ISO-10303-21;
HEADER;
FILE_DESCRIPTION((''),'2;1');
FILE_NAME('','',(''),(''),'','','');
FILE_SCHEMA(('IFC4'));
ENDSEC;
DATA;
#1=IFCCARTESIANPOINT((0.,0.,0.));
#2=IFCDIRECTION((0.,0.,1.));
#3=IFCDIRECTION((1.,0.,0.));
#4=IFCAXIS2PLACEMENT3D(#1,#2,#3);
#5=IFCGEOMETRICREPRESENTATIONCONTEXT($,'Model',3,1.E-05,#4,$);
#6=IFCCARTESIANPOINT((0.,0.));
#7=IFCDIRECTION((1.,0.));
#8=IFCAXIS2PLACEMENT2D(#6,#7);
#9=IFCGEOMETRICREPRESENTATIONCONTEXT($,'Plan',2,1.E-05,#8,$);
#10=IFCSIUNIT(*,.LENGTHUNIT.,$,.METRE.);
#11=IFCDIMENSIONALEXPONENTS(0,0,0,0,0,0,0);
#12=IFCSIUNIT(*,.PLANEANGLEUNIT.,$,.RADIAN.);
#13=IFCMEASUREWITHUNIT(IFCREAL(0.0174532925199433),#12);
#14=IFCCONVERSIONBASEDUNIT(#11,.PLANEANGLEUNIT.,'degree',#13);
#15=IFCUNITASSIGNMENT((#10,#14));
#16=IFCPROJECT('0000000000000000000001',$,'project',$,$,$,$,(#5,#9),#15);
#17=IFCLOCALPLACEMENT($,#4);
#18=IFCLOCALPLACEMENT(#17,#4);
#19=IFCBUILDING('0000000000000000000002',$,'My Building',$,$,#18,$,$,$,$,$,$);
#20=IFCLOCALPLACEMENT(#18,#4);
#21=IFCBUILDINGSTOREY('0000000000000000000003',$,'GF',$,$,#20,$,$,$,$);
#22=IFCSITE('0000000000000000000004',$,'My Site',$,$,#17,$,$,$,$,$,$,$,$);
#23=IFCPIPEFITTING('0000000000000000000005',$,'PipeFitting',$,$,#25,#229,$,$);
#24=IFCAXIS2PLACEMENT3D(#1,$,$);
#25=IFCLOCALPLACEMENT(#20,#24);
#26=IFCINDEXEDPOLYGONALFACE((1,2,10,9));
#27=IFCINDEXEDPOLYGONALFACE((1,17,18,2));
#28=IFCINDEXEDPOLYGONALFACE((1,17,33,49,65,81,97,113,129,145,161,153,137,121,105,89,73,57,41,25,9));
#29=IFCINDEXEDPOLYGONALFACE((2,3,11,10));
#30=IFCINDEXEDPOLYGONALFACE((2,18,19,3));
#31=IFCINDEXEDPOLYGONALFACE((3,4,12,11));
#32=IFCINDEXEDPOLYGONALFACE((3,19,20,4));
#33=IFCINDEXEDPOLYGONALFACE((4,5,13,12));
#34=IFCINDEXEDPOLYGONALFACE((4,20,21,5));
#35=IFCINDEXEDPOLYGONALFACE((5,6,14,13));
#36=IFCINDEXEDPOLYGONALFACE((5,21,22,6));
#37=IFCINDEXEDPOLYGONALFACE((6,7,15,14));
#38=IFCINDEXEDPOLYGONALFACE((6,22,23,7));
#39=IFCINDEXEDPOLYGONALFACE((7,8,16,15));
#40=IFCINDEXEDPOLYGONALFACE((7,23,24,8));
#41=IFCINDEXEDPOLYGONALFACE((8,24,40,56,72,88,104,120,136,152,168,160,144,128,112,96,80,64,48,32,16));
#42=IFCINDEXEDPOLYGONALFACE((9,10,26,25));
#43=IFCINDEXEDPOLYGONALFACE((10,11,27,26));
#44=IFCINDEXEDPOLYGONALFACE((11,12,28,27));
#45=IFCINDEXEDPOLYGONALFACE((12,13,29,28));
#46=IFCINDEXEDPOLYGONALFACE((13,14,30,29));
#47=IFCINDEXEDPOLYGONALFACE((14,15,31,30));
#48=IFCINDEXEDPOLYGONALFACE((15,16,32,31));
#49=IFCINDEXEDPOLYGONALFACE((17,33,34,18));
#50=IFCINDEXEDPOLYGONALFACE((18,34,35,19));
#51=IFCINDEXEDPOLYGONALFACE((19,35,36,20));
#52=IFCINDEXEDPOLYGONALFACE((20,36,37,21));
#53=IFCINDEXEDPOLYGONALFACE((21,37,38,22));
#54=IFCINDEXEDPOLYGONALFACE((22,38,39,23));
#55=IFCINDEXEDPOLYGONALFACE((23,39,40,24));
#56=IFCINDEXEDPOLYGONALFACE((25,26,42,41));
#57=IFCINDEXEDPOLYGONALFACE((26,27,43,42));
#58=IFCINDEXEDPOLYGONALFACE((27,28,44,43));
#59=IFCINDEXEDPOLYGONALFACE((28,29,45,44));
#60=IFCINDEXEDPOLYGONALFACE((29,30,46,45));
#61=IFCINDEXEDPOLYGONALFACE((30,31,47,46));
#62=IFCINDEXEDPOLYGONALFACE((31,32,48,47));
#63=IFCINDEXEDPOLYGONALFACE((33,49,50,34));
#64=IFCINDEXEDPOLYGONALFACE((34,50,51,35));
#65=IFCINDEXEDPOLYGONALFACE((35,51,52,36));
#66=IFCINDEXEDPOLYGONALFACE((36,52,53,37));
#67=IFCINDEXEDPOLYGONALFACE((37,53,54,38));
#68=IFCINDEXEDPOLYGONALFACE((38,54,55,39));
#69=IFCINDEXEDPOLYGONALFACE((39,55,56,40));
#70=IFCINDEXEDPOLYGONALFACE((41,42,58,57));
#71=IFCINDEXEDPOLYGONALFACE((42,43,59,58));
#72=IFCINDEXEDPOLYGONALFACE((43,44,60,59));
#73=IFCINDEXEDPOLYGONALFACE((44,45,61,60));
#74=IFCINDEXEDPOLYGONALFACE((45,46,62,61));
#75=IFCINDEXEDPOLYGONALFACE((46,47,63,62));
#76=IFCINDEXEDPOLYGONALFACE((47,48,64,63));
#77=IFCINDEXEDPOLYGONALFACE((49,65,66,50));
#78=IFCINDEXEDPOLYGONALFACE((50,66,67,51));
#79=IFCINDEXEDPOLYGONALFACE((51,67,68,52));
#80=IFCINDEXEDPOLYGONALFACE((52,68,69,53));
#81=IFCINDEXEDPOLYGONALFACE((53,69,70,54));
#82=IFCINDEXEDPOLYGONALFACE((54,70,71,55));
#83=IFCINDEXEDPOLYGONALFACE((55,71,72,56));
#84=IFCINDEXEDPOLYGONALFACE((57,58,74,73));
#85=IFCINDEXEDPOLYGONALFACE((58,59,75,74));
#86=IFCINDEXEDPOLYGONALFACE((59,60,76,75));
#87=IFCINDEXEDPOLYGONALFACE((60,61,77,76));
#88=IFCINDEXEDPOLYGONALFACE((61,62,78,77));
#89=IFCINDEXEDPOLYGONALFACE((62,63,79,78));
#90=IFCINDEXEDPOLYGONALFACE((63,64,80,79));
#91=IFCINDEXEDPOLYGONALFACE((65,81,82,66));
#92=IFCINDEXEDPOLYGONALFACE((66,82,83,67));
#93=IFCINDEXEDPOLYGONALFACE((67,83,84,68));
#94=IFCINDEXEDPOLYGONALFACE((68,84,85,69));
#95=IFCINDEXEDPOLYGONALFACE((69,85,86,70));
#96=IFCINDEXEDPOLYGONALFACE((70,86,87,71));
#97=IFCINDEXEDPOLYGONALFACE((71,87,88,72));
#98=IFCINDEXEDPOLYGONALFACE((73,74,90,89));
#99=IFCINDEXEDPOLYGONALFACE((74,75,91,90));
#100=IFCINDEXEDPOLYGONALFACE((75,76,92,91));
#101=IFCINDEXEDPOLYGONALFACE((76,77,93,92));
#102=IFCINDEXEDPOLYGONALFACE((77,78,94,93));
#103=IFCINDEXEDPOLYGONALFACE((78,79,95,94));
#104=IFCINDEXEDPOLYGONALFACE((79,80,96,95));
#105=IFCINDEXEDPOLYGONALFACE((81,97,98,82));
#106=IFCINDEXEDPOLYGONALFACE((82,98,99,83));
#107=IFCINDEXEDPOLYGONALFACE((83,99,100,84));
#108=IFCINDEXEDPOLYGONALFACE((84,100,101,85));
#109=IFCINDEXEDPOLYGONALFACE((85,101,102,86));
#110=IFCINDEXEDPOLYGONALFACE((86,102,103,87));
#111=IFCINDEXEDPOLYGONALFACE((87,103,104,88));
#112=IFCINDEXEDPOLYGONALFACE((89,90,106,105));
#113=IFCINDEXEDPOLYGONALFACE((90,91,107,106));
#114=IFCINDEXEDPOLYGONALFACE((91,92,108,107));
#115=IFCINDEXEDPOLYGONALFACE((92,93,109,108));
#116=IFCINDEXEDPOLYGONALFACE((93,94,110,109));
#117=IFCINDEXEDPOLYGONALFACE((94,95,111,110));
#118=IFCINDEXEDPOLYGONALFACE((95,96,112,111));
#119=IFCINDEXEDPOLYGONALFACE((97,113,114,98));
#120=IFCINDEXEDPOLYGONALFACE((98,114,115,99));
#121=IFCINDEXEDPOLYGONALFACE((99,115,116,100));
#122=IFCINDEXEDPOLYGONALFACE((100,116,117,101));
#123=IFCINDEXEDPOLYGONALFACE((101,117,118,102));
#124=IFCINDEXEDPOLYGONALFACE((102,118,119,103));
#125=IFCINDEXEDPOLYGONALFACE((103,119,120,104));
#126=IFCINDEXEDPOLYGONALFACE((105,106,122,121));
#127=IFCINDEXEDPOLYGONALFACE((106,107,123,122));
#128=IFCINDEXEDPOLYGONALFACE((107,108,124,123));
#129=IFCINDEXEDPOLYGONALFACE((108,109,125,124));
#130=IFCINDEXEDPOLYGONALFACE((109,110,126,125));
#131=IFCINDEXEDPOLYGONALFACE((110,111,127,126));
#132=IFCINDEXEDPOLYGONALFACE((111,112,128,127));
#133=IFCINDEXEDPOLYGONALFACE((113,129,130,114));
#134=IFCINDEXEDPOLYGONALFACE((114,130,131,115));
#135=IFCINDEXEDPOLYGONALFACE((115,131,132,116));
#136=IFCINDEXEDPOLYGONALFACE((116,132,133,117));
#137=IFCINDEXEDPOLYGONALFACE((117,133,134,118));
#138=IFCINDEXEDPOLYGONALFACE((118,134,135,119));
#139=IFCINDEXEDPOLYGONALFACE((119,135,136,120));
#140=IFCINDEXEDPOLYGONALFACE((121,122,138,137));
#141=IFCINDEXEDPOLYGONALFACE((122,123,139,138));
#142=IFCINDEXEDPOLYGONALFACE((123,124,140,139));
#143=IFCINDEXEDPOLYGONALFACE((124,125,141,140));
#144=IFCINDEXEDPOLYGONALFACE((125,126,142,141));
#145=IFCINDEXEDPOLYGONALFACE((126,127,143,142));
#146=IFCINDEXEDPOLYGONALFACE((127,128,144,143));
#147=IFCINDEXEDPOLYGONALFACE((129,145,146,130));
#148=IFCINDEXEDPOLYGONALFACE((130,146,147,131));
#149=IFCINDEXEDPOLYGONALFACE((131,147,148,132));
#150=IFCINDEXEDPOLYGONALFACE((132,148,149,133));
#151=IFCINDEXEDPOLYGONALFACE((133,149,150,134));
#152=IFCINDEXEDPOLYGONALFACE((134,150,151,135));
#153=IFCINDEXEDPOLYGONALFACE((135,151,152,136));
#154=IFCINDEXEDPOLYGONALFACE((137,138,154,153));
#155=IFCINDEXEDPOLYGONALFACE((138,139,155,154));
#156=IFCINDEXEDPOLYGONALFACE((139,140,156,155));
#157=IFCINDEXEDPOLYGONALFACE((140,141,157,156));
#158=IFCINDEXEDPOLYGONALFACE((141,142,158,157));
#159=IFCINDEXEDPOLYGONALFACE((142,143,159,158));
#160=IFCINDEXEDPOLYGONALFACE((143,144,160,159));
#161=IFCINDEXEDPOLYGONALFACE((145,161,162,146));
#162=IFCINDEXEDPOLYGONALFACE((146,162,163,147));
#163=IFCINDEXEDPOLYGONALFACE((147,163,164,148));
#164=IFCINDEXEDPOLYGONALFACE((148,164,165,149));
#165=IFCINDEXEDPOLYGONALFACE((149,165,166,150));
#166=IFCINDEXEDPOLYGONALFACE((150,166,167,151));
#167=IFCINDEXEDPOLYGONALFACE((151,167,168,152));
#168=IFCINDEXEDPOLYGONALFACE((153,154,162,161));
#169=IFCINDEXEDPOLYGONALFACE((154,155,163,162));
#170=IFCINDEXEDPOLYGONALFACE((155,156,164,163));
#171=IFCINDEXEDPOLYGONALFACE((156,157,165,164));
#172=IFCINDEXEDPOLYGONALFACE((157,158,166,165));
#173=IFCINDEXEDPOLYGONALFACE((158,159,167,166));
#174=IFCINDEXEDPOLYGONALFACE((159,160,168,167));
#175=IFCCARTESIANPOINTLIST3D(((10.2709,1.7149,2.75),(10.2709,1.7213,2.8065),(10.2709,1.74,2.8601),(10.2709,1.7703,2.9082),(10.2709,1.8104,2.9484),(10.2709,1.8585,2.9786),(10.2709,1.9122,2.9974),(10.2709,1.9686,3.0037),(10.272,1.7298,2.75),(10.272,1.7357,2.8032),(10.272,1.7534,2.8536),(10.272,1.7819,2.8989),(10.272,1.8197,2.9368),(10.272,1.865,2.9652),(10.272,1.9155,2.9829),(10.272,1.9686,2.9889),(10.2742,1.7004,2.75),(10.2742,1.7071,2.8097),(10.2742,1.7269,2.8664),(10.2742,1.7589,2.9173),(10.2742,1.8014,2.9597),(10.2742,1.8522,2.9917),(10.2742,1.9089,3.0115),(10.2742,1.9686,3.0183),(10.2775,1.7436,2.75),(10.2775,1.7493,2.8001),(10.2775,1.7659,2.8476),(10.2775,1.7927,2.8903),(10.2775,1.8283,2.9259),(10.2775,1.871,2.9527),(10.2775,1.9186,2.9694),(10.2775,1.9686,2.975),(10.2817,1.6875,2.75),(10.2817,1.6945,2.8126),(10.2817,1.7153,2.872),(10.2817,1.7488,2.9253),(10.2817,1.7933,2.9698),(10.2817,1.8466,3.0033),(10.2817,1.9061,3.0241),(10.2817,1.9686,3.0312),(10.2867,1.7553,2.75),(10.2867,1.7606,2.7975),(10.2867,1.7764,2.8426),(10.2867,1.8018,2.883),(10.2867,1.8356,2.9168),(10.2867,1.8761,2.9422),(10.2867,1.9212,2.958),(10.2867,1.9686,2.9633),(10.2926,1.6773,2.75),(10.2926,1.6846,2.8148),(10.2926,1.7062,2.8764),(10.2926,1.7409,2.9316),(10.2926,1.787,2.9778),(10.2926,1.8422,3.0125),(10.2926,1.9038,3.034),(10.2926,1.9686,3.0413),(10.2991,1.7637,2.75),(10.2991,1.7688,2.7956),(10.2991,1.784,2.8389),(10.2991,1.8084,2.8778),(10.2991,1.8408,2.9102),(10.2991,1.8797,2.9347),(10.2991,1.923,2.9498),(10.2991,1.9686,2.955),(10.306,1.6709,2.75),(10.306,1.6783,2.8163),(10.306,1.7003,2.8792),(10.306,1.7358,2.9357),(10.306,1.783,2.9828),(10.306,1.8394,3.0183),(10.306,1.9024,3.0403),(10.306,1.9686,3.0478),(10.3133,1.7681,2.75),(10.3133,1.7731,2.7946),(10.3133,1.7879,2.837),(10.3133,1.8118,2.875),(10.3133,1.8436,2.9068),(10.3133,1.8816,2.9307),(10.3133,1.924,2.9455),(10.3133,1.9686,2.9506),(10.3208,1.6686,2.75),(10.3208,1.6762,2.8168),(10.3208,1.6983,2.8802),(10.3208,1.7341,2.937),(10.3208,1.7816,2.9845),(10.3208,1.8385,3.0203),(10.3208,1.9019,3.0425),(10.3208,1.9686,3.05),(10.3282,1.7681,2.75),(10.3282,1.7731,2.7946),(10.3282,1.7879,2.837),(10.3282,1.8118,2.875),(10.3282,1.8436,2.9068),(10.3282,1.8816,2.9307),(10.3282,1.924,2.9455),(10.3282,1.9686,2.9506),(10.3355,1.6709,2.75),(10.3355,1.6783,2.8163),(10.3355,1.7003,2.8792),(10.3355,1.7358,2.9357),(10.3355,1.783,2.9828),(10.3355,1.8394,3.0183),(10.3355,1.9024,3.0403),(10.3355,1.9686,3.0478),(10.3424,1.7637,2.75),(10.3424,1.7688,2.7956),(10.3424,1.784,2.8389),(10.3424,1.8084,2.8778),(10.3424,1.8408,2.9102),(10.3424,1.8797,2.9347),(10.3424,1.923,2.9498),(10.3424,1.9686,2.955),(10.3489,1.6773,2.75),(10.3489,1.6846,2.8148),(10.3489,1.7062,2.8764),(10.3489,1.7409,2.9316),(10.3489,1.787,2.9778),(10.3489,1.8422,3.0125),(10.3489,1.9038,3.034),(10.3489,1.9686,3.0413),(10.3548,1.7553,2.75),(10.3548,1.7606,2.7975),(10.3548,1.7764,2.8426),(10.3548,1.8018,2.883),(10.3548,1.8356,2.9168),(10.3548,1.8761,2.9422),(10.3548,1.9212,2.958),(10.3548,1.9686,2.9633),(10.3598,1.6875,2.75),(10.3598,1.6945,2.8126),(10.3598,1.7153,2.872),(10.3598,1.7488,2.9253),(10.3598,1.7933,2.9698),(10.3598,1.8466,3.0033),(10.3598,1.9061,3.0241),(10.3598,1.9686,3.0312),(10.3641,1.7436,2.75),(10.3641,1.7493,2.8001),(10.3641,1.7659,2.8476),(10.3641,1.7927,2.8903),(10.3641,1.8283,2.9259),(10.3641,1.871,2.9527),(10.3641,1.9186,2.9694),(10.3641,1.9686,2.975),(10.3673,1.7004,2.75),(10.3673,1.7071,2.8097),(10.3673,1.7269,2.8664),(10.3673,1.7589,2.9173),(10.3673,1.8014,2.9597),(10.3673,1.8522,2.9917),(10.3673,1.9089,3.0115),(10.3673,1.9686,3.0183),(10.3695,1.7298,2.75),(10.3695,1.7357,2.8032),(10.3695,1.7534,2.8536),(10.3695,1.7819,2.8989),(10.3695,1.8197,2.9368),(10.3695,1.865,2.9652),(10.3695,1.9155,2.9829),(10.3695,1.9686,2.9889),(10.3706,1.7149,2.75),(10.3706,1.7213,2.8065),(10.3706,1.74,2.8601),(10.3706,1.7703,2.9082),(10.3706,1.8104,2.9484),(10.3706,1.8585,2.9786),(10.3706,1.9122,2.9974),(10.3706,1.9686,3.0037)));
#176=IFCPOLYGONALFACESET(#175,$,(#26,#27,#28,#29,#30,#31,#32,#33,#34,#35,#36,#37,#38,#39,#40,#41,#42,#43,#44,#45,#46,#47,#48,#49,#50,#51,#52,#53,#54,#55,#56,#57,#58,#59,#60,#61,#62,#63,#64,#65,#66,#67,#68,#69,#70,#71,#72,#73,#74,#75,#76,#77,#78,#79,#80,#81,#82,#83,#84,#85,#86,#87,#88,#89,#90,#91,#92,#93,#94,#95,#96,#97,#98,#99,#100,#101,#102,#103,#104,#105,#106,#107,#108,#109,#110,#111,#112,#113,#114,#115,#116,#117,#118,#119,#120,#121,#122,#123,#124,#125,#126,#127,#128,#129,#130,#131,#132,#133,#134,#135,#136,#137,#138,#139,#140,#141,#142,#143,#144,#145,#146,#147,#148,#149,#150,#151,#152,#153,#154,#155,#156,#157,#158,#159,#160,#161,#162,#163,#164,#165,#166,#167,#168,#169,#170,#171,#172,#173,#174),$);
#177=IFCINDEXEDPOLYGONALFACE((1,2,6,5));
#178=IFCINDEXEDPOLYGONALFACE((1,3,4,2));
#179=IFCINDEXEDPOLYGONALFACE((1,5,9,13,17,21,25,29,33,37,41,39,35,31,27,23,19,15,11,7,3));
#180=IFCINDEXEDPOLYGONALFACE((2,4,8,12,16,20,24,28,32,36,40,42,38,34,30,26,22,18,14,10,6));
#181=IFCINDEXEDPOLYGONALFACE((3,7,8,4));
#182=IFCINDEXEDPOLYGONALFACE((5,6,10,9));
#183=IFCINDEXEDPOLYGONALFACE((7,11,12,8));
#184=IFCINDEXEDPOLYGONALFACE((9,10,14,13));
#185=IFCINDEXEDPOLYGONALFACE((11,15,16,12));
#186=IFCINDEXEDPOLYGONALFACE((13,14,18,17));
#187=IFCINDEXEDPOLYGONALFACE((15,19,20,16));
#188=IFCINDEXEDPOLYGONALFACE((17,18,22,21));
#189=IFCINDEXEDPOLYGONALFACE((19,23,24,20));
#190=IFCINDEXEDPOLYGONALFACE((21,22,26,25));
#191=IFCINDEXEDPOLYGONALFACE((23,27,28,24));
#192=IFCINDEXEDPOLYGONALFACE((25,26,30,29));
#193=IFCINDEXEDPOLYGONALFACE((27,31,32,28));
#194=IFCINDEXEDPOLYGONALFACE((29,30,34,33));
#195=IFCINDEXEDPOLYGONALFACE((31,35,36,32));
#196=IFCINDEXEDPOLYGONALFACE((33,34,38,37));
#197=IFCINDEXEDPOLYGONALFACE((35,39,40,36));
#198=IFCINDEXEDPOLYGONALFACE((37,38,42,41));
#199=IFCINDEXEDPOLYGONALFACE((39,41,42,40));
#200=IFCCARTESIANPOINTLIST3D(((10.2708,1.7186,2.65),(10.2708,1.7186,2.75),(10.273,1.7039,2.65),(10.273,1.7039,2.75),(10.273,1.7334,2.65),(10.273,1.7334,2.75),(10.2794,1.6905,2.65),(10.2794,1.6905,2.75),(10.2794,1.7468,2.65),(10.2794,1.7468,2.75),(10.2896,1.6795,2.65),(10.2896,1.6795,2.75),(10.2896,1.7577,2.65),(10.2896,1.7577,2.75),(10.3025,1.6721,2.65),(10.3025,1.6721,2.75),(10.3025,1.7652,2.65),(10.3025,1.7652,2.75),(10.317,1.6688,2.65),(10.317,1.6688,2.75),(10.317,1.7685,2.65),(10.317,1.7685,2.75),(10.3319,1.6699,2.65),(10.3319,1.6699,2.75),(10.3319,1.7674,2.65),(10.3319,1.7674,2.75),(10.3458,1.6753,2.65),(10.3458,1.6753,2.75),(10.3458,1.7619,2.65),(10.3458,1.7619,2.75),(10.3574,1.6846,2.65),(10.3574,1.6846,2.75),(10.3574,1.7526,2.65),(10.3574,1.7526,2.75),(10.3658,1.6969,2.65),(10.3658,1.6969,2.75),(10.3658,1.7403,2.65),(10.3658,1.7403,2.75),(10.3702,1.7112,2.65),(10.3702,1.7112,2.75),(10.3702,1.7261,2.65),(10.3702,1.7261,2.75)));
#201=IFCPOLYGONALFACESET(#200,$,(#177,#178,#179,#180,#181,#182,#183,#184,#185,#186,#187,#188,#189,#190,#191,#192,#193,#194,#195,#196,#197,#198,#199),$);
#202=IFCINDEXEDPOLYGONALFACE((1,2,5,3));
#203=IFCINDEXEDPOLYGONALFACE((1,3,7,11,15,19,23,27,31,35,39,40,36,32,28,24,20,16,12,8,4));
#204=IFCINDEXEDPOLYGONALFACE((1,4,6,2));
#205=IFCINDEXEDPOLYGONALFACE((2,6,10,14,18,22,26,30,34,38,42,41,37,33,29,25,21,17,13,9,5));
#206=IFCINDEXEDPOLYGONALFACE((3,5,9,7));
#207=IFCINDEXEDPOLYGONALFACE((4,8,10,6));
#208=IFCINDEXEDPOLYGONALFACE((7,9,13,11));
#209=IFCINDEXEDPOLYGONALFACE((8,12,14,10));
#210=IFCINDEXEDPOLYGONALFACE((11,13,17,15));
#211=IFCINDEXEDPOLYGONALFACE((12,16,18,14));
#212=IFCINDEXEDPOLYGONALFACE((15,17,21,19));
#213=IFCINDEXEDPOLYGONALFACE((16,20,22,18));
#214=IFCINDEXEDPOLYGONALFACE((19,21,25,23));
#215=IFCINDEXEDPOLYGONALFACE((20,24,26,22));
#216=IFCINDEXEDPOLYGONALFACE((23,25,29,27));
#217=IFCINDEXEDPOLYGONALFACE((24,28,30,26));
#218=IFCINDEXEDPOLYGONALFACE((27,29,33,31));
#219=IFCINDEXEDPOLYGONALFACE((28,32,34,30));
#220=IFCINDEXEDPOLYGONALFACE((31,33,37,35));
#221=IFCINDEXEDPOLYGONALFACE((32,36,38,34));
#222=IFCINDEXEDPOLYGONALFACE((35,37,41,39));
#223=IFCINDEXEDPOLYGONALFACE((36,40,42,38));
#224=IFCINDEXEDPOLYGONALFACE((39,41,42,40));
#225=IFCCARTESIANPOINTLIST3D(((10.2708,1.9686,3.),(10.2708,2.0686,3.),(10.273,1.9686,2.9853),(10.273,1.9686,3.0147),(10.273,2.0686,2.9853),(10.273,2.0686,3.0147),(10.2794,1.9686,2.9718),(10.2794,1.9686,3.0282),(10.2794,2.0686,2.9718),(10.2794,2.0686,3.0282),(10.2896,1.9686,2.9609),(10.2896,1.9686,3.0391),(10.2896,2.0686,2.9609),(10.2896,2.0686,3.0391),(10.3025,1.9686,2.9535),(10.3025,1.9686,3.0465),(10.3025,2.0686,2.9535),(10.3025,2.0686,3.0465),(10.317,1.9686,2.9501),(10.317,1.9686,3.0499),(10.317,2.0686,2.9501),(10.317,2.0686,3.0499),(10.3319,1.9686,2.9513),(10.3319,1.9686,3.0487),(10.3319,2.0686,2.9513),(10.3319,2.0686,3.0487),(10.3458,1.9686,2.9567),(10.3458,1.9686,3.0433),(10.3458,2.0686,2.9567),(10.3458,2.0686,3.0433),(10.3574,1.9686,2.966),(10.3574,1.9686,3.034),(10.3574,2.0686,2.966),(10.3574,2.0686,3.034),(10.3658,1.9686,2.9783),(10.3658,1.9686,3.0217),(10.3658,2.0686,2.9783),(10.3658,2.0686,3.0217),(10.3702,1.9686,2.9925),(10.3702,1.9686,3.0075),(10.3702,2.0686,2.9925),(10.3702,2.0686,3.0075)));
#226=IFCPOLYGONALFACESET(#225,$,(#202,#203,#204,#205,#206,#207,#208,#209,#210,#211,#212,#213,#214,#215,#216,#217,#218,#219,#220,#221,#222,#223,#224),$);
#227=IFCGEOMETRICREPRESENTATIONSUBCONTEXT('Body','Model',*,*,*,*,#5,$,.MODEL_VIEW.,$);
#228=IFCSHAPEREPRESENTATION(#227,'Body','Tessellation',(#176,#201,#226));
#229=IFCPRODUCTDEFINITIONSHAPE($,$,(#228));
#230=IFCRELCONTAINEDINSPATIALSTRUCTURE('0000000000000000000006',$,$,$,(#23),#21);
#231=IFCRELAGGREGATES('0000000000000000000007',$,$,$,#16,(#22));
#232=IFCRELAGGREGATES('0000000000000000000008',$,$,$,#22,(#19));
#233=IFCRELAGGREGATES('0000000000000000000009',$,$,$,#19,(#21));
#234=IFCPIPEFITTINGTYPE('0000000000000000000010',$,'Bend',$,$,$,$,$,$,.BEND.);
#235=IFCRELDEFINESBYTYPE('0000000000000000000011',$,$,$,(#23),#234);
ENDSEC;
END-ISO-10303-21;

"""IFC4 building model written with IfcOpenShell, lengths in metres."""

from ifc_helpers import new_model, entity, si_unit, converted_unit, frame, origin_with_axes, origin_2d_with_axis, place, context, subcontext, project, spatial, circle, extrude, source, transform, mapped, type_object, type_shapes, element, save


model = new_model("IFC4")

# Units and contexts
model_context = context("Model", 3, precision=1e-05, world=origin_with_axes())
plan_context = context("Plan", 2, precision=1e-05, world=origin_2d_with_axis())
body_context = subcontext(model_context, "Body", "Model", "MODEL_VIEW")
ifc_project = project(units=[si_unit("LENGTHUNIT", "METRE"), converted_unit("PLANEANGLEUNIT", "degree", entity("IfcReal", 0.0174532925199433), si_unit("PLANEANGLEUNIT", "RADIAN"), dimensions=[0, 0, 0, 0, 0, 0, 0])], contexts=[model_context, plan_context])

# Site, building, storey
site_placement = place(None, origin_with_axes())
site = spatial("IfcSite", under=ifc_project, at=site_placement, Name="My Site")
building_placement = place(site_placement, origin_with_axes())
building = spatial("IfcBuilding", under=site, at=building_placement, Name="My Building")
storey_placement = place(building_placement, origin_with_axes())
storey = spatial("IfcBuildingStorey", under=building, at=storey_placement, Name="GF")

# Pipe fitting
pipe_fitting_type = type_object("IfcPipeFittingType", Name="Bend", PredefinedType="BEND")
shared_shape = source(origin_with_axes(), body_context, "Body", "SolidModel", [
    entity("IfcSweptDiskSolid", entity("IfcIndexedPolyCurve", entity("IfcCartesianPointList3D", [[0.0, 0.0, -0.1], [0.0, 0.0732, -0.2768], [0.0, 0.25, -0.35]]), [entity("IfcArcIndex", [1, 2, 3])]), 0.05),
    extrude(circle(Radius=0.05), origin_with_axes(), (0.0, 0.0, -1.0), 0.1),
    extrude(circle(Radius=0.05), frame((0.0, 0.25, -0.35), z_axis=(0.0, 1.0, 0.0), x_axis=(1.0, 0.0, 0.0)), (0.0, 0.0, 1.0), 0.1),
])
type_shapes(pipe_fitting_type, [shared_shape])
for number, where, z_axis, x_axis, name in (
    (1, (10.3208, 1.7186, 2.65), (0.0, 0.0, -1.0), (-1.0, 0.0, 0.0), "PipeFitting"),
):
    element("IfcPipeFitting", number, at=place(storey_placement, frame(where, z_axis=z_axis, x_axis=x_axis)), inside=storey, type_object=pipe_fitting_type, Name=name, context=body_context, shape_type="MappedRepresentation", body=[
        mapped(shared_shape, transform((0.0, 0.0, 0.0), x_axis=(1.0, 0.0, 0.0), y_axis=(0.0, 1.0, 0.0), z_axis=(0.0, 0.0, 1.0), scale=1.0)),
    ])

save(model, "model.ifc")
